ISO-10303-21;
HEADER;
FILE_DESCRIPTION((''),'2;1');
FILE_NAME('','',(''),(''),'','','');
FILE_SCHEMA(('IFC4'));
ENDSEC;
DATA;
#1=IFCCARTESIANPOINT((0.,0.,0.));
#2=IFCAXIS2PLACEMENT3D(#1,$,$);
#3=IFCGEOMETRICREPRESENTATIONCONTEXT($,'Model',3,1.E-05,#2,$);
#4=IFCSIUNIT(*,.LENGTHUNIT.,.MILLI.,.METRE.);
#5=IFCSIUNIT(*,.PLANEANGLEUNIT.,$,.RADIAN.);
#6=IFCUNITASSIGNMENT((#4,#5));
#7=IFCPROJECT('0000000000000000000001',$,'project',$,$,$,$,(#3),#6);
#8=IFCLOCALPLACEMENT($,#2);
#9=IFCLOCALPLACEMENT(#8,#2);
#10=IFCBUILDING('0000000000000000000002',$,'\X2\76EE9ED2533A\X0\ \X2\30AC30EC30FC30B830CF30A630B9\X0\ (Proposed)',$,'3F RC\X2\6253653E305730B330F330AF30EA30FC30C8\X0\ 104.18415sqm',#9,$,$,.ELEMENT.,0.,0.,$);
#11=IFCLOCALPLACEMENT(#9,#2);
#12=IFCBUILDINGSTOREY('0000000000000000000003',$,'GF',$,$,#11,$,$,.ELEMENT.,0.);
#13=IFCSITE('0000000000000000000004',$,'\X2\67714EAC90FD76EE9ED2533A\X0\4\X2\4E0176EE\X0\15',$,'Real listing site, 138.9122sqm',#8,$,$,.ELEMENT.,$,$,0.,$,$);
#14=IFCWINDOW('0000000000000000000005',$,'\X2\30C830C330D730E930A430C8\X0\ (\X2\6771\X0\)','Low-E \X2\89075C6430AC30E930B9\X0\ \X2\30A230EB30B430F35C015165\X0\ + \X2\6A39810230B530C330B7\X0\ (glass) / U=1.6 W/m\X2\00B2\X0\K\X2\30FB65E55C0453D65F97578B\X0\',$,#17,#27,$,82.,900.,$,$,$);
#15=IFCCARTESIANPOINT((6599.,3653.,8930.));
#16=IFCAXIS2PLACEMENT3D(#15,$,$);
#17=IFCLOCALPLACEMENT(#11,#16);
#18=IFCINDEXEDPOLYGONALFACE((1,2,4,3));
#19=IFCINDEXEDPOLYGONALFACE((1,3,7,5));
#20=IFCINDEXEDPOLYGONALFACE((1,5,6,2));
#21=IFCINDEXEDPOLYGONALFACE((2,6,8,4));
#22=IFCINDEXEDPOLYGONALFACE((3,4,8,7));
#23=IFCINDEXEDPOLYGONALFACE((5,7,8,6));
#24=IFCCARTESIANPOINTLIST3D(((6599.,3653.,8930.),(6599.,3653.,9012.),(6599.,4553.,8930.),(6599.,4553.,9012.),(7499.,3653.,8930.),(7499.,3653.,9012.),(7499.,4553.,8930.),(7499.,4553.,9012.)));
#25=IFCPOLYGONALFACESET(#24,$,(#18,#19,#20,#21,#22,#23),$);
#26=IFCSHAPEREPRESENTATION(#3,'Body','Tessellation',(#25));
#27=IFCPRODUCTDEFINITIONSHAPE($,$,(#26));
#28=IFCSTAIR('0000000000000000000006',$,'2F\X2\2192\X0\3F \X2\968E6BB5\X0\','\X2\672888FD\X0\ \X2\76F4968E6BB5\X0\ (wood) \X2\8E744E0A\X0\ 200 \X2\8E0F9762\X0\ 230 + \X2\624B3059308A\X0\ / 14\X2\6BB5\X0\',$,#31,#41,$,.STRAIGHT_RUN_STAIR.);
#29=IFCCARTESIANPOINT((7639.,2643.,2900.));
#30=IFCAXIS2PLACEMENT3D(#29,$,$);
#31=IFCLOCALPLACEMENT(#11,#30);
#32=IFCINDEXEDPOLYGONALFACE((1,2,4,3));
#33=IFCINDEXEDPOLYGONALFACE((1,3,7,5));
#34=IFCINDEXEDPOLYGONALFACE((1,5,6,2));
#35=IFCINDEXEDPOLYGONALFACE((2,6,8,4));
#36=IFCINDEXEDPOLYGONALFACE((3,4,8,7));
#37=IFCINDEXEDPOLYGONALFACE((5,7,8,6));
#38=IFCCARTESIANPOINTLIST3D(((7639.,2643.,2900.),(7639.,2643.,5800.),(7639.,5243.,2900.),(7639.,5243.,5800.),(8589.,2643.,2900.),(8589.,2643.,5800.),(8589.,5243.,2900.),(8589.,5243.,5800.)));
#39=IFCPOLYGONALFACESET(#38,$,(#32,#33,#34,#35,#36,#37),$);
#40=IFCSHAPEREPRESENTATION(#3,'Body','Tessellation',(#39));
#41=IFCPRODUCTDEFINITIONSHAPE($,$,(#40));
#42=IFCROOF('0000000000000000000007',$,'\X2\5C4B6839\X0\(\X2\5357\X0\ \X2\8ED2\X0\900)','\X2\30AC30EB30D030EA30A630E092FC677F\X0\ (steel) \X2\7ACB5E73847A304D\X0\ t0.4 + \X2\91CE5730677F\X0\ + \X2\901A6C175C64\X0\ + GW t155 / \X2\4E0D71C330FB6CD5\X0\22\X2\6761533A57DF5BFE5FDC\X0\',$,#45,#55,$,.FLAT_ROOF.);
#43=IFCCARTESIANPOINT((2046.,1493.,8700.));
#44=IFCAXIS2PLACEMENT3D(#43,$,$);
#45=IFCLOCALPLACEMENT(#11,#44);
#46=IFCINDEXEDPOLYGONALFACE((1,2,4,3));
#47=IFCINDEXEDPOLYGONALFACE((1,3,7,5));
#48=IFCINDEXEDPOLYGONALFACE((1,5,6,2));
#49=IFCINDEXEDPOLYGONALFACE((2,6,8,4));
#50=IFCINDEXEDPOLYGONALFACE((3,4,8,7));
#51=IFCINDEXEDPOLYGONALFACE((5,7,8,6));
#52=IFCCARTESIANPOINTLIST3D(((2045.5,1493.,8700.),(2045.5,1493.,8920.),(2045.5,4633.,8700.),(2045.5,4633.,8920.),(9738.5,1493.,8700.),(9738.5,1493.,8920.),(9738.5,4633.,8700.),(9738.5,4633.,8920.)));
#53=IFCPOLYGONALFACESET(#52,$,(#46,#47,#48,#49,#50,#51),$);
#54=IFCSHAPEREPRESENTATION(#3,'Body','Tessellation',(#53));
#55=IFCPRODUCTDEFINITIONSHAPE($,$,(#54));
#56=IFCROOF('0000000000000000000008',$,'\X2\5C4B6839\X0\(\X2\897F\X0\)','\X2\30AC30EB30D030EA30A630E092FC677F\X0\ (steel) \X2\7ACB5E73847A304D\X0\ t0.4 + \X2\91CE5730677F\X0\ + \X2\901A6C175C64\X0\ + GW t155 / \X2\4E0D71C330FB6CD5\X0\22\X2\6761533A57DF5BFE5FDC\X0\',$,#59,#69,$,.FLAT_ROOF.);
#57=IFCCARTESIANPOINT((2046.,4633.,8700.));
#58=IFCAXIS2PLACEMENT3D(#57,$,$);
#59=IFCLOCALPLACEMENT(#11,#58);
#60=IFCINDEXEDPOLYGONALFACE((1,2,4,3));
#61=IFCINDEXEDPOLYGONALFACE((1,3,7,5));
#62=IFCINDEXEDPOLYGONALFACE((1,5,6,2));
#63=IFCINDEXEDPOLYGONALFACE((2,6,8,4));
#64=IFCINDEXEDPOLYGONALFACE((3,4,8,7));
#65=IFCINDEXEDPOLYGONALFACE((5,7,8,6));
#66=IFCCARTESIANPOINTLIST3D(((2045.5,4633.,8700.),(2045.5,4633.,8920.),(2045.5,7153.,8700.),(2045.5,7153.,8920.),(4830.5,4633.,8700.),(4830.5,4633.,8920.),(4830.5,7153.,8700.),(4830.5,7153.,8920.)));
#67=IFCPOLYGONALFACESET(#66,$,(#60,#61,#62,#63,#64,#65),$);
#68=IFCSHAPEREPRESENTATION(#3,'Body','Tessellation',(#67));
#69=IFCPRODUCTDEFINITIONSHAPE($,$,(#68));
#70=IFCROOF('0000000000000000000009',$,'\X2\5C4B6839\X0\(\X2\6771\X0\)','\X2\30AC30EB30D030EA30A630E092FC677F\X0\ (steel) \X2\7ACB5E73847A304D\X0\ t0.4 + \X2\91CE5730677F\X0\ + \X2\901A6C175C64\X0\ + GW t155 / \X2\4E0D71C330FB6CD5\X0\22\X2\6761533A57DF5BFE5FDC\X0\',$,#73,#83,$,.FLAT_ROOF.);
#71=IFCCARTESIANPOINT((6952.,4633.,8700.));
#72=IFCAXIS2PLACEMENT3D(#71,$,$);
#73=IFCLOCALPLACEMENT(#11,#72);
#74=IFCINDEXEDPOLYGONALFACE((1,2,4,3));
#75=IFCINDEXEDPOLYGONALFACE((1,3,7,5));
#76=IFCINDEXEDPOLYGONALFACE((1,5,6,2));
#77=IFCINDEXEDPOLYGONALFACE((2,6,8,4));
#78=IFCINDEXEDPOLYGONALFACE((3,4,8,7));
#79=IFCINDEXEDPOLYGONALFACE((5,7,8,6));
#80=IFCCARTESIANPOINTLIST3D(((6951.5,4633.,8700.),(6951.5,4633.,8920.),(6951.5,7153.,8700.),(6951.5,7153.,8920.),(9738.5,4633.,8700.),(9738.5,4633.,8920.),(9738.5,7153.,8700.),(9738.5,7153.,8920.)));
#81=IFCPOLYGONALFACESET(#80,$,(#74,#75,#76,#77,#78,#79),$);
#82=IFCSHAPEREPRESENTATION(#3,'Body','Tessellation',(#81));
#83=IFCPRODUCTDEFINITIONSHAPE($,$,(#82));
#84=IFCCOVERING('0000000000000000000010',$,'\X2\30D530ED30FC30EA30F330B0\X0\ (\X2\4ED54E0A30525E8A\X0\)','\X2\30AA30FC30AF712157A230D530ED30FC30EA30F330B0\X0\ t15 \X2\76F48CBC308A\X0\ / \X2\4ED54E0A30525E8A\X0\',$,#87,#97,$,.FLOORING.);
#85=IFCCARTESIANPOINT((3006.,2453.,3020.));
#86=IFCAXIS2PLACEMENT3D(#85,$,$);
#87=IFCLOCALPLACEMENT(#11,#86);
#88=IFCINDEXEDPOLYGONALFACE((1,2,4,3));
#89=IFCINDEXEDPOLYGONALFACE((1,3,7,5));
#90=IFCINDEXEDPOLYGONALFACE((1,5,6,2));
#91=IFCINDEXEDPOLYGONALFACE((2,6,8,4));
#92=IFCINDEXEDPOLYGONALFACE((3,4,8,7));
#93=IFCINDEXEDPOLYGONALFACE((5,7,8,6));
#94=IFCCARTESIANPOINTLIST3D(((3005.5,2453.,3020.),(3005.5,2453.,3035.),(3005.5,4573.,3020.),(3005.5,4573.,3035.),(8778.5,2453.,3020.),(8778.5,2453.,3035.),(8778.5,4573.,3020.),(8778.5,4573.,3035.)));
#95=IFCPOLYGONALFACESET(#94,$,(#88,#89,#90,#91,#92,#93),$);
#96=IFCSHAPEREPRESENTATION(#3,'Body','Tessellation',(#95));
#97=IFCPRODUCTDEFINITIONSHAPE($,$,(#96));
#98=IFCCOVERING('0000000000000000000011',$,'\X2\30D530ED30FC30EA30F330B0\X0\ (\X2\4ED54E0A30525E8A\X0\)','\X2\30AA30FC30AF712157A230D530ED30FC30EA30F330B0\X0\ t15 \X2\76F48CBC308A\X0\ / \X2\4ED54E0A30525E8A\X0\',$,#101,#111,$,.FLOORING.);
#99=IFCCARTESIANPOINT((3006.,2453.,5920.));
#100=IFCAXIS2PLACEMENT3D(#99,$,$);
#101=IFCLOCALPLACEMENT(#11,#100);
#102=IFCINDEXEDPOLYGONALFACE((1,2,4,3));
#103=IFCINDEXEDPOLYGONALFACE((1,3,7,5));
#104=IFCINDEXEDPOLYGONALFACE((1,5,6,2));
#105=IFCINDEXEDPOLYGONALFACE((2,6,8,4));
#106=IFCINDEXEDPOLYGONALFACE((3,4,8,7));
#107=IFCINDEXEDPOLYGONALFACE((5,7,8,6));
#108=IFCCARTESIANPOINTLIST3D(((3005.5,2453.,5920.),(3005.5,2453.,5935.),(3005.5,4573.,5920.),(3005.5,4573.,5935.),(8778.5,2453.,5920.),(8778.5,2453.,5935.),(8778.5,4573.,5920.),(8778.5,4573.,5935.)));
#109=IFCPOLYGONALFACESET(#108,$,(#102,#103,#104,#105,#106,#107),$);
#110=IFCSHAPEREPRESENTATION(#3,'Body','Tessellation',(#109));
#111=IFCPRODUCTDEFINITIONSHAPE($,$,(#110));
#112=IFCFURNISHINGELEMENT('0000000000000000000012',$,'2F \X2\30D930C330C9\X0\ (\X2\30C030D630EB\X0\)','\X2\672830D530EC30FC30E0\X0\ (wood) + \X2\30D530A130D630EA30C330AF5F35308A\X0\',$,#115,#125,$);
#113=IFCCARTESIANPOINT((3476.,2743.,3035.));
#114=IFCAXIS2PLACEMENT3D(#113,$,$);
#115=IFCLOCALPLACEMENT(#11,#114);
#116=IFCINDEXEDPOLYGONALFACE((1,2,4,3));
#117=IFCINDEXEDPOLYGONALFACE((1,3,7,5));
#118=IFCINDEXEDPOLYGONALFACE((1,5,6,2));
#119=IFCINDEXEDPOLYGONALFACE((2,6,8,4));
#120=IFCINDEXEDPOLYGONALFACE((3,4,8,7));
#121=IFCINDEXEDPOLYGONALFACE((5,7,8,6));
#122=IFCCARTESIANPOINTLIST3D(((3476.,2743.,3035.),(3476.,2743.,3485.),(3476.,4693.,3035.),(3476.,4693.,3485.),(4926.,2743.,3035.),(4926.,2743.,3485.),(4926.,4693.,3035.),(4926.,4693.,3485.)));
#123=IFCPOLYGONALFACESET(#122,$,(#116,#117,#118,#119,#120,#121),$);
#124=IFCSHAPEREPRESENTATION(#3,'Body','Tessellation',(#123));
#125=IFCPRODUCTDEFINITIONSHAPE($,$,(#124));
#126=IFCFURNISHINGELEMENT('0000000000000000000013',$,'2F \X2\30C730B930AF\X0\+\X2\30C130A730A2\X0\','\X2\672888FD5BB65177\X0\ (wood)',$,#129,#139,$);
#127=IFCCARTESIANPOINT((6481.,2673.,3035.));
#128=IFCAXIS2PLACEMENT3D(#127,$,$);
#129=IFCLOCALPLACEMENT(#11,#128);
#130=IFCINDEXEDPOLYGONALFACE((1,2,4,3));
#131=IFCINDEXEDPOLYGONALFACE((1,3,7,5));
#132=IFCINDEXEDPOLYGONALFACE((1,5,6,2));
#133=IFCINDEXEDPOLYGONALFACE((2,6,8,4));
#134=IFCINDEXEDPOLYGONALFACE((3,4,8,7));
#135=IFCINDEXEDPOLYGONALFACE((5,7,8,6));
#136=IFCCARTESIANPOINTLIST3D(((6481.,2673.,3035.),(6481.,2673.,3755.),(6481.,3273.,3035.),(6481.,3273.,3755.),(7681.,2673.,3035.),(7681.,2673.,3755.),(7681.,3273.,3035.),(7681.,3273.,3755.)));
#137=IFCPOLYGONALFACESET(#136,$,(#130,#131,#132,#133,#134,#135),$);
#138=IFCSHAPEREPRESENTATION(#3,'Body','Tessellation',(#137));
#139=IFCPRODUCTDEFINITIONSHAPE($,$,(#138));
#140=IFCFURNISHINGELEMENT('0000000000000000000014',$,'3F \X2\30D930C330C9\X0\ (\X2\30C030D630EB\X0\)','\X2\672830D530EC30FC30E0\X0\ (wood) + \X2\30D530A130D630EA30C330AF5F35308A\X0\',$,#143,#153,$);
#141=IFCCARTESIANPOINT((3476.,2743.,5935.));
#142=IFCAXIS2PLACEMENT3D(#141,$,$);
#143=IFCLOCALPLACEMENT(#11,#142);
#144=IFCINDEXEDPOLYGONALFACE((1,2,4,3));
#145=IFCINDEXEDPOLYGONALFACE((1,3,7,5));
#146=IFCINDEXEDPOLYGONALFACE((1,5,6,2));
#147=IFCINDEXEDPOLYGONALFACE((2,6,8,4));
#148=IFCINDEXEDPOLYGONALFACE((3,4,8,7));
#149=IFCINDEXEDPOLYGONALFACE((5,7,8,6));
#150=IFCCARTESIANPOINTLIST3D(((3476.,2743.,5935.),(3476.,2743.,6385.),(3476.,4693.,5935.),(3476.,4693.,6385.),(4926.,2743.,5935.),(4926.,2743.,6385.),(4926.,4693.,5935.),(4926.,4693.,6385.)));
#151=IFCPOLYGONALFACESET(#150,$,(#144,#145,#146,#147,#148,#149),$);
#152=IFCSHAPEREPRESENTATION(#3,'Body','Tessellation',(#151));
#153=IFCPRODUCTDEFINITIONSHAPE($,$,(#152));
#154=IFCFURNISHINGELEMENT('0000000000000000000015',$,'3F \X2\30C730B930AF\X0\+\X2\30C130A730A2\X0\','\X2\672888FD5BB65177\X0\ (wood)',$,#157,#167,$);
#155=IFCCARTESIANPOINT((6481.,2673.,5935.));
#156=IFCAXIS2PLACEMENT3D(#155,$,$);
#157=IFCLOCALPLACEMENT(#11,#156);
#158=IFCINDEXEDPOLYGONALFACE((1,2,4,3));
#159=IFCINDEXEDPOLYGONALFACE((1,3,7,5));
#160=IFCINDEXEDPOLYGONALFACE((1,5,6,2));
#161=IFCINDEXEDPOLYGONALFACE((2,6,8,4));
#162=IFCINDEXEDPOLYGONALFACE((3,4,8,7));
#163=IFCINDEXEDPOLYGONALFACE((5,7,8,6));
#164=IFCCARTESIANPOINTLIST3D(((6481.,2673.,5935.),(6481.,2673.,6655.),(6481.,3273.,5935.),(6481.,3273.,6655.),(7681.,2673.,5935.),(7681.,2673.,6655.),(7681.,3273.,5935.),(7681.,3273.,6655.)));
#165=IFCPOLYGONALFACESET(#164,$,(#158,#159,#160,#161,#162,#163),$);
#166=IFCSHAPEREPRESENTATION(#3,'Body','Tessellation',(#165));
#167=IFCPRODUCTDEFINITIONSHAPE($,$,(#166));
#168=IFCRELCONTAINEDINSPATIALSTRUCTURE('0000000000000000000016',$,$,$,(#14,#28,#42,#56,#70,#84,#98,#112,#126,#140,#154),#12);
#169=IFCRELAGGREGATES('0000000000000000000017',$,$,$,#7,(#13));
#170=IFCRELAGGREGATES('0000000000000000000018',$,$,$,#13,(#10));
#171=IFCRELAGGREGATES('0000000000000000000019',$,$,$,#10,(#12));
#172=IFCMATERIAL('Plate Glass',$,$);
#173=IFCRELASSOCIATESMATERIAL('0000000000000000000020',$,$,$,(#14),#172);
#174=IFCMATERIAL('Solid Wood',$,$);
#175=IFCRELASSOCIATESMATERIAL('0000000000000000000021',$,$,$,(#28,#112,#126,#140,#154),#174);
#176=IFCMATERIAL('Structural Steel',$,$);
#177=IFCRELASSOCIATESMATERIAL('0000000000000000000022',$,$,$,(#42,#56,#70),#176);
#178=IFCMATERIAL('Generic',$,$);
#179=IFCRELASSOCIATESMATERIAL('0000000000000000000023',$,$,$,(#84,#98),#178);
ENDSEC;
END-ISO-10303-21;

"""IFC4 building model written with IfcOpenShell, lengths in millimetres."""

from ifc_helpers import new_model, si_unit, frame, frame_2d, origin, place, context, project, spatial, rectangle, extrude, material, element, save


model = new_model("IFC4")

# Units and contexts
model_context = context("Model", 3, precision=1e-05, world=origin())
ifc_project = project(units=[si_unit("LENGTHUNIT", "METRE", prefix="MILLI"), si_unit("PLANEANGLEUNIT", "RADIAN")], contexts=[model_context])

# Site, building, storey
site_placement = place(None, origin())
site = spatial("IfcSite", under=ifc_project, at=site_placement, Name="東京都目黒区4丁目15", ObjectType="Real listing site, 138.9122sqm", CompositionType="ELEMENT", RefElevation=0.0)
building_placement = place(site_placement, origin())
building = spatial("IfcBuilding", under=site, at=building_placement, Name="目黒区 ガレージハウス (Proposed)", ObjectType="3F RC打放しコンクリート 104.18415sqm", CompositionType="ELEMENT", ElevationOfRefHeight=0.0, ElevationOfTerrain=0.0)
storey_placement = place(building_placement, origin())
storey = spatial("IfcBuildingStorey", under=building, at=storey_placement, Name="GF", CompositionType="ELEMENT", Elevation=0.0)

# Shared definitions
ifc_material_1 = material(Name="Solid Wood")

# Shared definitions
ifc_material_2 = material(Name="Plate Glass")

# Window
window_1_placement = place(storey_placement, frame((6599.0, 3653.0, 8930.0)))
element("IfcWindow", 1, at=window_1_placement, inside=storey, material=ifc_material_2, Name="トップライト (東)", Description="Low-E 複層ガラス アルゴン封入 + 樹脂サッシ (glass) / U=1.6 W/m²K・日射取得型", OverallHeight=82.0, OverallWidth=900.0, context=model_context, shape_type="SweptSolid", body=[
    extrude(rectangle(XDim=900.0, YDim=900.0, at=frame_2d((450.0, 450.0))), frame((6599.0, 3653.0, 8930.0)), (0.0, 0.0, 1.0), 82.0),
])

# Stair
stair_placement = place(storey_placement, frame((7639.0, 2643.0, 2900.0)))
element("IfcStair", 2, at=stair_placement, inside=storey, material=ifc_material_1, Name="2F→3F 階段", Description="木製 直階段 (wood) 蹴上 200 踏面 230 + 手すり / 14段", PredefinedType="STRAIGHT_RUN_STAIR", context=model_context, shape_type="SweptSolid", body=[
    extrude(rectangle(XDim=950.0, YDim=2600.0, at=frame_2d((475.0, 1300.0))), frame((7639.0, 2643.0, 2900.0)), (0.0, 0.0, 1.0), 2900.0),
])

# Roofs
ifc_material_3 = material(Name="Structural Steel")
roof_1_placement = place(storey_placement, frame((2046.0, 1493.0, 8700.0)))
element("IfcRoof", 3, at=roof_1_placement, inside=storey, material=ifc_material_3, Name="屋根(南 軒900)", Description="ガルバリウム鋼板 (steel) 立平葺き t0.4 + 野地板 + 通気層 + GW t155 / 不燃・法22条区域対応", PredefinedType="FLAT_ROOF", context=model_context, shape_type="SweptSolid", body=[
    extrude(rectangle(XDim=7693.0, YDim=3140.0, at=frame_2d((3846.0, 1570.0))), frame((2046.0, 1493.0, 8700.0)), (0.0, 0.0, 1.0), 220.0),
])
roof_2_placement = place(storey_placement, frame((2046.0, 4633.0, 8700.0)))
element("IfcRoof", 4, at=roof_2_placement, inside=storey, material=ifc_material_3, Name="屋根(西)", Description="ガルバリウム鋼板 (steel) 立平葺き t0.4 + 野地板 + 通気層 + GW t155 / 不燃・法22条区域対応", PredefinedType="FLAT_ROOF", context=model_context, shape_type="SweptSolid", body=[
    extrude(rectangle(XDim=2785.0, YDim=2520.0, at=frame_2d((1392.0, 1260.0))), frame((2046.0, 4633.0, 8700.0)), (0.0, 0.0, 1.0), 220.0),
])
roof_3_placement = place(storey_placement, frame((6952.0, 4633.0, 8700.0)))
element("IfcRoof", 5, at=roof_3_placement, inside=storey, material=ifc_material_3, Name="屋根(東)", Description="ガルバリウム鋼板 (steel) 立平葺き t0.4 + 野地板 + 通気層 + GW t155 / 不燃・法22条区域対応", PredefinedType="FLAT_ROOF", context=model_context, shape_type="SweptSolid", body=[
    extrude(rectangle(XDim=2787.0, YDim=2520.0, at=frame_2d((1393.0, 1260.0))), frame((6952.0, 4633.0, 8700.0)), (0.0, 0.0, 1.0), 220.0),
])

# Coverings
ifc_material_4 = material(Name="Generic")
covering_1_placement = place(storey_placement, frame((3006.0, 2453.0, 3020.0)))
element("IfcCovering", 6, at=covering_1_placement, inside=storey, material=ifc_material_4, Name="フローリング (仕上げ床)", Description="オーク無垢フローリング t15 直貼り / 仕上げ床", PredefinedType="FLOORING", context=model_context, shape_type="SweptSolid", body=[
    extrude(rectangle(XDim=5773.0, YDim=2120.0, at=frame_2d((2886.0, 1060.0))), frame((3006.0, 2453.0, 3020.0)), (0.0, 0.0, 1.0), 15.0),
])
covering_2_placement = place(storey_placement, frame((3006.0, 2453.0, 5920.0)))
element("IfcCovering", 7, at=covering_2_placement, inside=storey, material=ifc_material_4, Name="フローリング (仕上げ床)", Description="オーク無垢フローリング t15 直貼り / 仕上げ床", PredefinedType="FLOORING", context=model_context, shape_type="SweptSolid", body=[
    extrude(rectangle(XDim=5773.0, YDim=2120.0, at=frame_2d((2886.0, 1060.0))), frame((3006.0, 2453.0, 5920.0)), (0.0, 0.0, 1.0), 15.0),
])

# Furnishing elements
furnishing_1_placement = place(storey_placement, frame((3476.0, 2743.0, 3035.0)))
element("IfcFurnishingElement", 8, at=furnishing_1_placement, inside=storey, material=ifc_material_1, Name="2F ベッド (ダブル)", Description="木フレーム (wood) + ファブリック張り", context=model_context, shape_type="SweptSolid", body=[
    extrude(rectangle(XDim=1450.0, YDim=1950.0, at=frame_2d((725.0, 975.0))), frame((3476.0, 2743.0, 3035.0)), (0.0, 0.0, 1.0), 450.0),
])
furnishing_2_placement = place(storey_placement, frame((6481.0, 2673.0, 3035.0)))
element("IfcFurnishingElement", 9, at=furnishing_2_placement, inside=storey, material=ifc_material_1, Name="2F デスク+チェア", Description="木製家具 (wood)", context=model_context, shape_type="SweptSolid", body=[
    extrude(rectangle(XDim=1200.0, YDim=600.0, at=frame_2d((600.0, 300.0))), frame((6481.0, 2673.0, 3035.0)), (0.0, 0.0, 1.0), 720.0),
])
furnishing_3_placement = place(storey_placement, frame((3476.0, 2743.0, 5935.0)))
element("IfcFurnishingElement", 10, at=furnishing_3_placement, inside=storey, material=ifc_material_1, Name="3F ベッド (ダブル)", Description="木フレーム (wood) + ファブリック張り", context=model_context, shape_type="SweptSolid", body=[
    extrude(rectangle(XDim=1450.0, YDim=1950.0, at=frame_2d((725.0, 975.0))), frame((3476.0, 2743.0, 5935.0)), (0.0, 0.0, 1.0), 450.0),
])
furnishing_4_placement = place(storey_placement, frame((6481.0, 2673.0, 5935.0)))
element("IfcFurnishingElement", 11, at=furnishing_4_placement, inside=storey, material=ifc_material_1, Name="3F デスク+チェア", Description="木製家具 (wood)", context=model_context, shape_type="SweptSolid", body=[
    extrude(rectangle(XDim=1200.0, YDim=600.0, at=frame_2d((600.0, 300.0))), frame((6481.0, 2673.0, 5935.0)), (0.0, 0.0, 1.0), 720.0),
])

save(model, "model.ifc")
